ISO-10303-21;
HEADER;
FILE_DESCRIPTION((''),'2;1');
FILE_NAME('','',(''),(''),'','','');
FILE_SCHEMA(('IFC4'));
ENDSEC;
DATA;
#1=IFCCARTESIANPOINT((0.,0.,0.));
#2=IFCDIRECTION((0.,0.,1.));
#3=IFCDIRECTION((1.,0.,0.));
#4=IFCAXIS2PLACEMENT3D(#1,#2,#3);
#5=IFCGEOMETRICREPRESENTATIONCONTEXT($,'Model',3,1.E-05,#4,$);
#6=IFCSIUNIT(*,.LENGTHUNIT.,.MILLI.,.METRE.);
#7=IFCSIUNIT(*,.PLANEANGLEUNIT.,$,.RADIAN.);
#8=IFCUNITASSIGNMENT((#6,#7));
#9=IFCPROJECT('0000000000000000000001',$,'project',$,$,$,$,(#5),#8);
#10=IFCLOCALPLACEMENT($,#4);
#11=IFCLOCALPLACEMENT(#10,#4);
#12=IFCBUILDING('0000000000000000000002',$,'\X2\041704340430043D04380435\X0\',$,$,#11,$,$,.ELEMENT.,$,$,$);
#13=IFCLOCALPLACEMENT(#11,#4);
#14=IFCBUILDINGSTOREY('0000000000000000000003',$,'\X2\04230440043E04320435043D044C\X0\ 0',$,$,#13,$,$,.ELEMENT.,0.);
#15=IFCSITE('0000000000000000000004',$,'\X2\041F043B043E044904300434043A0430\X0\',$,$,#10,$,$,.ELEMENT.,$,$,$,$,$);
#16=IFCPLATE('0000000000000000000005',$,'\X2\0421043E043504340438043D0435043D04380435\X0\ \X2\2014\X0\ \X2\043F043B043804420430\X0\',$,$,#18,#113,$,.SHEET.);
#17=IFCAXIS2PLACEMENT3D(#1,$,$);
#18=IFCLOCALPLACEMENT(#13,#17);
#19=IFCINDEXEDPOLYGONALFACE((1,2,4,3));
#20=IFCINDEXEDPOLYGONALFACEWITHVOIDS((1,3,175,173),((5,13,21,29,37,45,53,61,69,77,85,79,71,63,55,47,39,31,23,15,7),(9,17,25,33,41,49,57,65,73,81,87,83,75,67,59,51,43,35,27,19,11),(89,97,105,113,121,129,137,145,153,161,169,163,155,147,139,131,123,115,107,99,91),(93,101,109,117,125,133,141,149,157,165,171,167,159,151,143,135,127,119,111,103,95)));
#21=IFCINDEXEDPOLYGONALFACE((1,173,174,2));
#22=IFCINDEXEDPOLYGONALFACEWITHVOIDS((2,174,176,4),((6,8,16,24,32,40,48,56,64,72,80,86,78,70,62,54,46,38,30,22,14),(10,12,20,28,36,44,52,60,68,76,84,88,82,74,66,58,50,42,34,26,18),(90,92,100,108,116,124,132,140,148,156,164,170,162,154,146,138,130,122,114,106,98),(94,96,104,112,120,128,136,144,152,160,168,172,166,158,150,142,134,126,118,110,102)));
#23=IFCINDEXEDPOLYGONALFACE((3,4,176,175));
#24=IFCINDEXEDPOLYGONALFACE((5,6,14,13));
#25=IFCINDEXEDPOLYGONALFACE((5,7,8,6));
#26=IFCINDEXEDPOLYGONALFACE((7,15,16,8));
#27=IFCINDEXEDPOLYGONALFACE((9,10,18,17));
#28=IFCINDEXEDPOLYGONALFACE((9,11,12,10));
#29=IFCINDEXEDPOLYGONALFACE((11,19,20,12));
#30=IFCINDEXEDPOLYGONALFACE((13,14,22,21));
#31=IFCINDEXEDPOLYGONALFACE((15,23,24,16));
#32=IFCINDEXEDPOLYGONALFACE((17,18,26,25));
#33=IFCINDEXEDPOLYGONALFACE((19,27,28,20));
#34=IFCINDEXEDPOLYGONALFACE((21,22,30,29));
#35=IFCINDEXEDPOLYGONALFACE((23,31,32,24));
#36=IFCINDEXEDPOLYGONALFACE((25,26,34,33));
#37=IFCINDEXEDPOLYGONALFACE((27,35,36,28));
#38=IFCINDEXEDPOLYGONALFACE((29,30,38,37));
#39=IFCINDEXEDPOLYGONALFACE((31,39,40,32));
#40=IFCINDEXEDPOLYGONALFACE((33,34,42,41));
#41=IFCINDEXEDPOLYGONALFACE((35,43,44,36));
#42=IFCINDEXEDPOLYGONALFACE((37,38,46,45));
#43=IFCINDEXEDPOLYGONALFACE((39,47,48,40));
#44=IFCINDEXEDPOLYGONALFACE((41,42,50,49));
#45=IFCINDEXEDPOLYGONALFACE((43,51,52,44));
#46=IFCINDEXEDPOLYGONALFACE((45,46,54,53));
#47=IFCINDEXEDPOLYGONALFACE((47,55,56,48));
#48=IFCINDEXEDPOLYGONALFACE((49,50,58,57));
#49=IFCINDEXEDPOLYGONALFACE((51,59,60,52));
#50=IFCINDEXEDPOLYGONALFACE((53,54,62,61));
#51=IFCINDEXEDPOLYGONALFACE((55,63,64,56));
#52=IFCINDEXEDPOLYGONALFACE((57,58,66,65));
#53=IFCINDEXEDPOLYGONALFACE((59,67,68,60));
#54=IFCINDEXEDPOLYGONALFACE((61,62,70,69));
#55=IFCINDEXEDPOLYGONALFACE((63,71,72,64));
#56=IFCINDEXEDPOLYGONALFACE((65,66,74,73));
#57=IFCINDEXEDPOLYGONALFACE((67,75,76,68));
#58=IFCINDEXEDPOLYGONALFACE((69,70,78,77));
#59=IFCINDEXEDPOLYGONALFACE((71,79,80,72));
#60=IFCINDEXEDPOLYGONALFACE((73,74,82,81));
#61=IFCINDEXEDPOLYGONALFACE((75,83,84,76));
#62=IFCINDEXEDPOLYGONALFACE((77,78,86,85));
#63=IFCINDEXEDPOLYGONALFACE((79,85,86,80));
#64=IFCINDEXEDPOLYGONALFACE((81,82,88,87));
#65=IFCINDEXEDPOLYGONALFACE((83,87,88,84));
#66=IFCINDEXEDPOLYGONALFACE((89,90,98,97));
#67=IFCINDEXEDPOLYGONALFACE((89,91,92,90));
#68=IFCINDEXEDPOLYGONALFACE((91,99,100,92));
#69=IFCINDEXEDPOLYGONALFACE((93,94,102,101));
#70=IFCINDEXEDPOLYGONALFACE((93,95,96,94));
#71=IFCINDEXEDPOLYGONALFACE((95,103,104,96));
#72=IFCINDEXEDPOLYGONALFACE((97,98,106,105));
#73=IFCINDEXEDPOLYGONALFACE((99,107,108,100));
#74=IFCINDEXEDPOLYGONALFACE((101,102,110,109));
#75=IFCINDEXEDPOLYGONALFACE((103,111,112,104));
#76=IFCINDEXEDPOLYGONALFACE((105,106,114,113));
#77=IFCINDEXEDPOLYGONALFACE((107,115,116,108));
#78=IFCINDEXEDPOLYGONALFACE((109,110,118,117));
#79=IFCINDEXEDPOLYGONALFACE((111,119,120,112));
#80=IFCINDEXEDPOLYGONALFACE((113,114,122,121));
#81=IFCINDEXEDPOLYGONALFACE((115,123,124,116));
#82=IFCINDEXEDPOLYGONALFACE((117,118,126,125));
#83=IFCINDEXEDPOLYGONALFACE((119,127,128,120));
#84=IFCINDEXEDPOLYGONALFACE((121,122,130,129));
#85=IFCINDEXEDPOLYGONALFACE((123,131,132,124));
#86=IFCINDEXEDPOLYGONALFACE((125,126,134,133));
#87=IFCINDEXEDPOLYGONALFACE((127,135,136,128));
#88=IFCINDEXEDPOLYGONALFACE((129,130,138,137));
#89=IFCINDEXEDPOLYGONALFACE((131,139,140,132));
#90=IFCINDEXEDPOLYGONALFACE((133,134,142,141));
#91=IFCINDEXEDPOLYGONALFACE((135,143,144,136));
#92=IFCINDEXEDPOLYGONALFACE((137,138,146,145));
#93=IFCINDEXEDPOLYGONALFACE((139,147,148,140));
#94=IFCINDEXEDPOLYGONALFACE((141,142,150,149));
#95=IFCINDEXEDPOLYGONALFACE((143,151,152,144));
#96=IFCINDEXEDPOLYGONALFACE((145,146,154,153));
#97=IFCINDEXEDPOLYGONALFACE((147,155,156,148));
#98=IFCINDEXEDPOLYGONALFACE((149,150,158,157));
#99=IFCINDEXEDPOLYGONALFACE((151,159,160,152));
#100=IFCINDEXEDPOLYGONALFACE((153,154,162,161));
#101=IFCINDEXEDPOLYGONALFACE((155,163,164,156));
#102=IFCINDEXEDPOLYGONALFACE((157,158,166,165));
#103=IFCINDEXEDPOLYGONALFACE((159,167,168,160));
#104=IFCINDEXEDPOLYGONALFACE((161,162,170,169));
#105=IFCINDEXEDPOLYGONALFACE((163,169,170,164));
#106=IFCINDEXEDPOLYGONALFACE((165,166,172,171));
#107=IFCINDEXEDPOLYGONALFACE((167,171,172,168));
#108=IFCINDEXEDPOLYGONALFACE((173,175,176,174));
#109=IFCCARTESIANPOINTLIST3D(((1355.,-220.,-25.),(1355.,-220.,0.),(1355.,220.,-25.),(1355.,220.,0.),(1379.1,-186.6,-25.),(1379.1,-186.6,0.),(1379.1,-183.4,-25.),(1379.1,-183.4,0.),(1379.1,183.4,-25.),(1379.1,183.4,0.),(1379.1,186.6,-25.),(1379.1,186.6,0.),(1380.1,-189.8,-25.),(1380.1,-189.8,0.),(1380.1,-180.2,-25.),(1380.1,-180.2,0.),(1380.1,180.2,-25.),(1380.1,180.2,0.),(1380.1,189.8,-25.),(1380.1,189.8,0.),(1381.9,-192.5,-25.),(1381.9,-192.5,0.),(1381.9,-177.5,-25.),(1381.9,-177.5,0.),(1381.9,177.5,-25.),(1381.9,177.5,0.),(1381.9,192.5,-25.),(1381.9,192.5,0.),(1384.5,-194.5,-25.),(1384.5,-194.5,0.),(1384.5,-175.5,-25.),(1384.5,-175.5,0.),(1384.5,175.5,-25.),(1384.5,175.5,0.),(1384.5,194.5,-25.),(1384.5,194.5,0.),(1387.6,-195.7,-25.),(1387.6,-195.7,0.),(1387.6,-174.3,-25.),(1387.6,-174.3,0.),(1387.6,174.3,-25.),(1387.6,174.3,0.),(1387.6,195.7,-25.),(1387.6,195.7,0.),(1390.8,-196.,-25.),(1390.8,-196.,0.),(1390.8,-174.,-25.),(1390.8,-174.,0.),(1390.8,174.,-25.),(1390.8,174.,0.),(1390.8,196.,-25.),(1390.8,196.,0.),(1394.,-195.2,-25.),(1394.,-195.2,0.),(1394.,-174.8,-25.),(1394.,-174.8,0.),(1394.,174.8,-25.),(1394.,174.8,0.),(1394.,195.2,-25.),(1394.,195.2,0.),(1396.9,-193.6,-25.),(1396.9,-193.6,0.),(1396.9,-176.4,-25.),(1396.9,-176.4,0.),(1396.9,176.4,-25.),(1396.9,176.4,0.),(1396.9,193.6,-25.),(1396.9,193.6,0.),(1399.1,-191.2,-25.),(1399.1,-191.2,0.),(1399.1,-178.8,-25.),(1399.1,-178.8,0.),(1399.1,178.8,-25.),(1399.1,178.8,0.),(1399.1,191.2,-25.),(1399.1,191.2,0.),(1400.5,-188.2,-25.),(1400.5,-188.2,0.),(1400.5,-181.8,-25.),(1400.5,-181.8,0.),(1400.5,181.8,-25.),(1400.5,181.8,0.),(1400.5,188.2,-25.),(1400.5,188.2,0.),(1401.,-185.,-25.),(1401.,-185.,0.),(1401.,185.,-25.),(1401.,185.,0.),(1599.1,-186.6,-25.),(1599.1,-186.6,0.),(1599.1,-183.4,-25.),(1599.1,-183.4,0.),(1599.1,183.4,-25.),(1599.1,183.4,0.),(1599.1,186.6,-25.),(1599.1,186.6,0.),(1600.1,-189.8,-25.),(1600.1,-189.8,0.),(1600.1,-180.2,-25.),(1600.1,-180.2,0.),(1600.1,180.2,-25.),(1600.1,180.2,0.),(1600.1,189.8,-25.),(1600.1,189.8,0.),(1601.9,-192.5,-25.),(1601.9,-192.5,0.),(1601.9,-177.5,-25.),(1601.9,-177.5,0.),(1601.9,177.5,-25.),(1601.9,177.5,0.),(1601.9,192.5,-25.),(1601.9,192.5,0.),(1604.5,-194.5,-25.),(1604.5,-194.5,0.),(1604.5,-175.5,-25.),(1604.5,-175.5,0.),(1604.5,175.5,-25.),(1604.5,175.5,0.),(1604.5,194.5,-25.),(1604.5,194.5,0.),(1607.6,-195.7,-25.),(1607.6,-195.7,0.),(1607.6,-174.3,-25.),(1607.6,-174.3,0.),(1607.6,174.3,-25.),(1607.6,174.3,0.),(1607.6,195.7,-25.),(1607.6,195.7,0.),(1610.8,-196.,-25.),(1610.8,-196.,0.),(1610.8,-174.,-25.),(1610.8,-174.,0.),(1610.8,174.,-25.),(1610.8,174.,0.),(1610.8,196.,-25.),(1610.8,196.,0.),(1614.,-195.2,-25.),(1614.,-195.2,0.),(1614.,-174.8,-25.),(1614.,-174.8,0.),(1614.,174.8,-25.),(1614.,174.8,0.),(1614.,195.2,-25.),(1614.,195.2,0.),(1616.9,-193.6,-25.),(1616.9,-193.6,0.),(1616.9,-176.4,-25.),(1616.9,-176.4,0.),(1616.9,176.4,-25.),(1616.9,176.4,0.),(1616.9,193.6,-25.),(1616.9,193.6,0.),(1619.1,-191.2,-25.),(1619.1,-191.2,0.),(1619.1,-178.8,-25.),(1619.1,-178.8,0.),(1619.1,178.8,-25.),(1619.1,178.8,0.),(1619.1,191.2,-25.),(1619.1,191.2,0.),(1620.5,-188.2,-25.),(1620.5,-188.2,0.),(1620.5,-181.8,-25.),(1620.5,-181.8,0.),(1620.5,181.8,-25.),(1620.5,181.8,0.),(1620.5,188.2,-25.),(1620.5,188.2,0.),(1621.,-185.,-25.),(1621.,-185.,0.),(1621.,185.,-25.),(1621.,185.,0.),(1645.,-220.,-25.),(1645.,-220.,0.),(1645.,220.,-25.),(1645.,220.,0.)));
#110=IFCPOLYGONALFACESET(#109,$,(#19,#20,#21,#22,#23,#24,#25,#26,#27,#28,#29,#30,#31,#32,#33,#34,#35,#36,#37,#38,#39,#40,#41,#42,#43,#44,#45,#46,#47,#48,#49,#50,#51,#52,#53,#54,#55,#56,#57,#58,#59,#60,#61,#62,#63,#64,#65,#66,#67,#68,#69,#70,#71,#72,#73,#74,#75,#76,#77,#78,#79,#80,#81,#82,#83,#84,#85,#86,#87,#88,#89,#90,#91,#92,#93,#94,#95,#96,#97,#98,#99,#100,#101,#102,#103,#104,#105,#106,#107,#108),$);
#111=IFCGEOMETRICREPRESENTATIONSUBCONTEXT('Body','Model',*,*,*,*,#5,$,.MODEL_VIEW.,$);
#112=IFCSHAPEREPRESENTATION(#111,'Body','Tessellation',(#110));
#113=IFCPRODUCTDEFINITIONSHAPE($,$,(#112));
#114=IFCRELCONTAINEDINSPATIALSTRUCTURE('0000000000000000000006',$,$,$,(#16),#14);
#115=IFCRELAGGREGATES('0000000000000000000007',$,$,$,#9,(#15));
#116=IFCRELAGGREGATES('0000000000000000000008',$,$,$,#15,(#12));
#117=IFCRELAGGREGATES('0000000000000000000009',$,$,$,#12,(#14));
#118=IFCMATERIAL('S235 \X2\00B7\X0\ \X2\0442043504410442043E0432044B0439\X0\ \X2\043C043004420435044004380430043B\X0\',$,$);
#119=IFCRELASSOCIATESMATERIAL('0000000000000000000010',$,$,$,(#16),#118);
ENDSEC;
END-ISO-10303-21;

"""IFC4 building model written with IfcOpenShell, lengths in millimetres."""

from ifc_helpers import new_model, si_unit, frame, origin_with_axes, place, context, subcontext, project, spatial, polyline, circle, outline, extrude, material, element, save


model = new_model("IFC4")

# Units and contexts
model_context = context("Model", 3, precision=1e-05, world=origin_with_axes())
body_context = subcontext(model_context, "Body", "Model", "MODEL_VIEW")
ifc_project = project(units=[si_unit("LENGTHUNIT", "METRE", prefix="MILLI"), si_unit("PLANEANGLEUNIT", "RADIAN")], contexts=[model_context])

# Site, building, storey
site_placement = place(None, origin_with_axes())
site = spatial("IfcSite", under=ifc_project, at=site_placement, Name="Площадка", CompositionType="ELEMENT")
building_placement = place(site_placement, origin_with_axes())
building = spatial("IfcBuilding", under=site, at=building_placement, Name="Здание", CompositionType="ELEMENT")
storey_placement = place(building_placement, origin_with_axes())
storey = spatial("IfcBuildingStorey", under=building, at=storey_placement, Name="Уровень 0", CompositionType="ELEMENT", Elevation=0.0)

# Shared definitions
ifc_material = material(Name="S235 · тестовый материал")

# Plate, openings
plate_1_placement = place(storey_placement, frame((1355.0, -220.0, -25.0), z_axis=(0.0, 0.0, 1.0), x_axis=(1.0, 0.0, 0.0)))
plate_1 = element("IfcPlate", 1, at=plate_1_placement, inside=storey, material=ifc_material, Name="Соединение — плита", PredefinedType="SHEET", context=body_context, shape_type="SweptSolid", body=[
    extrude(outline(polyline([(0.0, 0.0), (290.0, 0.0), (290.0, 440.0), (0.0, 440.0), (0.0, 0.0)])), origin_with_axes(), (0.0, 0.0, 1.0), 25.0),
])
opening_1_placement = place(plate_1_placement, frame((35.0, 35.0, -1.0), z_axis=(0.0, 0.0, 1.0), x_axis=(1.0, 0.0, 0.0)))
element("IfcOpeningElement", 2, at=opening_1_placement, cuts=plate_1, PredefinedType="OPENING", context=body_context, shape_type="SweptSolid", body=[
    extrude(circle(Radius=11.0), origin_with_axes(), (0.0, 0.0, 1.0), 27.0),
])
opening_2_placement = place(plate_1_placement, frame((255.0, 35.0, -1.0), z_axis=(0.0, 0.0, 1.0), x_axis=(1.0, 0.0, 0.0)))
element("IfcOpeningElement", 3, at=opening_2_placement, cuts=plate_1, PredefinedType="OPENING", context=body_context, shape_type="SweptSolid", body=[
    extrude(circle(Radius=11.0), origin_with_axes(), (0.0, 0.0, 1.0), 27.0),
])
opening_3_placement = place(plate_1_placement, frame((35.0, 405.0, -1.0), z_axis=(0.0, 0.0, 1.0), x_axis=(1.0, 0.0, 0.0)))
element("IfcOpeningElement", 4, at=opening_3_placement, cuts=plate_1, PredefinedType="OPENING", context=body_context, shape_type="SweptSolid", body=[
    extrude(circle(Radius=11.0), origin_with_axes(), (0.0, 0.0, 1.0), 27.0),
])
opening_4_placement = place(plate_1_placement, frame((255.0, 405.0, -1.0), z_axis=(0.0, 0.0, 1.0), x_axis=(1.0, 0.0, 0.0)))
element("IfcOpeningElement", 5, at=opening_4_placement, cuts=plate_1, PredefinedType="OPENING", context=body_context, shape_type="SweptSolid", body=[
    extrude(circle(Radius=11.0), origin_with_axes(), (0.0, 0.0, 1.0), 27.0),
])

save(model, "model.ifc")
